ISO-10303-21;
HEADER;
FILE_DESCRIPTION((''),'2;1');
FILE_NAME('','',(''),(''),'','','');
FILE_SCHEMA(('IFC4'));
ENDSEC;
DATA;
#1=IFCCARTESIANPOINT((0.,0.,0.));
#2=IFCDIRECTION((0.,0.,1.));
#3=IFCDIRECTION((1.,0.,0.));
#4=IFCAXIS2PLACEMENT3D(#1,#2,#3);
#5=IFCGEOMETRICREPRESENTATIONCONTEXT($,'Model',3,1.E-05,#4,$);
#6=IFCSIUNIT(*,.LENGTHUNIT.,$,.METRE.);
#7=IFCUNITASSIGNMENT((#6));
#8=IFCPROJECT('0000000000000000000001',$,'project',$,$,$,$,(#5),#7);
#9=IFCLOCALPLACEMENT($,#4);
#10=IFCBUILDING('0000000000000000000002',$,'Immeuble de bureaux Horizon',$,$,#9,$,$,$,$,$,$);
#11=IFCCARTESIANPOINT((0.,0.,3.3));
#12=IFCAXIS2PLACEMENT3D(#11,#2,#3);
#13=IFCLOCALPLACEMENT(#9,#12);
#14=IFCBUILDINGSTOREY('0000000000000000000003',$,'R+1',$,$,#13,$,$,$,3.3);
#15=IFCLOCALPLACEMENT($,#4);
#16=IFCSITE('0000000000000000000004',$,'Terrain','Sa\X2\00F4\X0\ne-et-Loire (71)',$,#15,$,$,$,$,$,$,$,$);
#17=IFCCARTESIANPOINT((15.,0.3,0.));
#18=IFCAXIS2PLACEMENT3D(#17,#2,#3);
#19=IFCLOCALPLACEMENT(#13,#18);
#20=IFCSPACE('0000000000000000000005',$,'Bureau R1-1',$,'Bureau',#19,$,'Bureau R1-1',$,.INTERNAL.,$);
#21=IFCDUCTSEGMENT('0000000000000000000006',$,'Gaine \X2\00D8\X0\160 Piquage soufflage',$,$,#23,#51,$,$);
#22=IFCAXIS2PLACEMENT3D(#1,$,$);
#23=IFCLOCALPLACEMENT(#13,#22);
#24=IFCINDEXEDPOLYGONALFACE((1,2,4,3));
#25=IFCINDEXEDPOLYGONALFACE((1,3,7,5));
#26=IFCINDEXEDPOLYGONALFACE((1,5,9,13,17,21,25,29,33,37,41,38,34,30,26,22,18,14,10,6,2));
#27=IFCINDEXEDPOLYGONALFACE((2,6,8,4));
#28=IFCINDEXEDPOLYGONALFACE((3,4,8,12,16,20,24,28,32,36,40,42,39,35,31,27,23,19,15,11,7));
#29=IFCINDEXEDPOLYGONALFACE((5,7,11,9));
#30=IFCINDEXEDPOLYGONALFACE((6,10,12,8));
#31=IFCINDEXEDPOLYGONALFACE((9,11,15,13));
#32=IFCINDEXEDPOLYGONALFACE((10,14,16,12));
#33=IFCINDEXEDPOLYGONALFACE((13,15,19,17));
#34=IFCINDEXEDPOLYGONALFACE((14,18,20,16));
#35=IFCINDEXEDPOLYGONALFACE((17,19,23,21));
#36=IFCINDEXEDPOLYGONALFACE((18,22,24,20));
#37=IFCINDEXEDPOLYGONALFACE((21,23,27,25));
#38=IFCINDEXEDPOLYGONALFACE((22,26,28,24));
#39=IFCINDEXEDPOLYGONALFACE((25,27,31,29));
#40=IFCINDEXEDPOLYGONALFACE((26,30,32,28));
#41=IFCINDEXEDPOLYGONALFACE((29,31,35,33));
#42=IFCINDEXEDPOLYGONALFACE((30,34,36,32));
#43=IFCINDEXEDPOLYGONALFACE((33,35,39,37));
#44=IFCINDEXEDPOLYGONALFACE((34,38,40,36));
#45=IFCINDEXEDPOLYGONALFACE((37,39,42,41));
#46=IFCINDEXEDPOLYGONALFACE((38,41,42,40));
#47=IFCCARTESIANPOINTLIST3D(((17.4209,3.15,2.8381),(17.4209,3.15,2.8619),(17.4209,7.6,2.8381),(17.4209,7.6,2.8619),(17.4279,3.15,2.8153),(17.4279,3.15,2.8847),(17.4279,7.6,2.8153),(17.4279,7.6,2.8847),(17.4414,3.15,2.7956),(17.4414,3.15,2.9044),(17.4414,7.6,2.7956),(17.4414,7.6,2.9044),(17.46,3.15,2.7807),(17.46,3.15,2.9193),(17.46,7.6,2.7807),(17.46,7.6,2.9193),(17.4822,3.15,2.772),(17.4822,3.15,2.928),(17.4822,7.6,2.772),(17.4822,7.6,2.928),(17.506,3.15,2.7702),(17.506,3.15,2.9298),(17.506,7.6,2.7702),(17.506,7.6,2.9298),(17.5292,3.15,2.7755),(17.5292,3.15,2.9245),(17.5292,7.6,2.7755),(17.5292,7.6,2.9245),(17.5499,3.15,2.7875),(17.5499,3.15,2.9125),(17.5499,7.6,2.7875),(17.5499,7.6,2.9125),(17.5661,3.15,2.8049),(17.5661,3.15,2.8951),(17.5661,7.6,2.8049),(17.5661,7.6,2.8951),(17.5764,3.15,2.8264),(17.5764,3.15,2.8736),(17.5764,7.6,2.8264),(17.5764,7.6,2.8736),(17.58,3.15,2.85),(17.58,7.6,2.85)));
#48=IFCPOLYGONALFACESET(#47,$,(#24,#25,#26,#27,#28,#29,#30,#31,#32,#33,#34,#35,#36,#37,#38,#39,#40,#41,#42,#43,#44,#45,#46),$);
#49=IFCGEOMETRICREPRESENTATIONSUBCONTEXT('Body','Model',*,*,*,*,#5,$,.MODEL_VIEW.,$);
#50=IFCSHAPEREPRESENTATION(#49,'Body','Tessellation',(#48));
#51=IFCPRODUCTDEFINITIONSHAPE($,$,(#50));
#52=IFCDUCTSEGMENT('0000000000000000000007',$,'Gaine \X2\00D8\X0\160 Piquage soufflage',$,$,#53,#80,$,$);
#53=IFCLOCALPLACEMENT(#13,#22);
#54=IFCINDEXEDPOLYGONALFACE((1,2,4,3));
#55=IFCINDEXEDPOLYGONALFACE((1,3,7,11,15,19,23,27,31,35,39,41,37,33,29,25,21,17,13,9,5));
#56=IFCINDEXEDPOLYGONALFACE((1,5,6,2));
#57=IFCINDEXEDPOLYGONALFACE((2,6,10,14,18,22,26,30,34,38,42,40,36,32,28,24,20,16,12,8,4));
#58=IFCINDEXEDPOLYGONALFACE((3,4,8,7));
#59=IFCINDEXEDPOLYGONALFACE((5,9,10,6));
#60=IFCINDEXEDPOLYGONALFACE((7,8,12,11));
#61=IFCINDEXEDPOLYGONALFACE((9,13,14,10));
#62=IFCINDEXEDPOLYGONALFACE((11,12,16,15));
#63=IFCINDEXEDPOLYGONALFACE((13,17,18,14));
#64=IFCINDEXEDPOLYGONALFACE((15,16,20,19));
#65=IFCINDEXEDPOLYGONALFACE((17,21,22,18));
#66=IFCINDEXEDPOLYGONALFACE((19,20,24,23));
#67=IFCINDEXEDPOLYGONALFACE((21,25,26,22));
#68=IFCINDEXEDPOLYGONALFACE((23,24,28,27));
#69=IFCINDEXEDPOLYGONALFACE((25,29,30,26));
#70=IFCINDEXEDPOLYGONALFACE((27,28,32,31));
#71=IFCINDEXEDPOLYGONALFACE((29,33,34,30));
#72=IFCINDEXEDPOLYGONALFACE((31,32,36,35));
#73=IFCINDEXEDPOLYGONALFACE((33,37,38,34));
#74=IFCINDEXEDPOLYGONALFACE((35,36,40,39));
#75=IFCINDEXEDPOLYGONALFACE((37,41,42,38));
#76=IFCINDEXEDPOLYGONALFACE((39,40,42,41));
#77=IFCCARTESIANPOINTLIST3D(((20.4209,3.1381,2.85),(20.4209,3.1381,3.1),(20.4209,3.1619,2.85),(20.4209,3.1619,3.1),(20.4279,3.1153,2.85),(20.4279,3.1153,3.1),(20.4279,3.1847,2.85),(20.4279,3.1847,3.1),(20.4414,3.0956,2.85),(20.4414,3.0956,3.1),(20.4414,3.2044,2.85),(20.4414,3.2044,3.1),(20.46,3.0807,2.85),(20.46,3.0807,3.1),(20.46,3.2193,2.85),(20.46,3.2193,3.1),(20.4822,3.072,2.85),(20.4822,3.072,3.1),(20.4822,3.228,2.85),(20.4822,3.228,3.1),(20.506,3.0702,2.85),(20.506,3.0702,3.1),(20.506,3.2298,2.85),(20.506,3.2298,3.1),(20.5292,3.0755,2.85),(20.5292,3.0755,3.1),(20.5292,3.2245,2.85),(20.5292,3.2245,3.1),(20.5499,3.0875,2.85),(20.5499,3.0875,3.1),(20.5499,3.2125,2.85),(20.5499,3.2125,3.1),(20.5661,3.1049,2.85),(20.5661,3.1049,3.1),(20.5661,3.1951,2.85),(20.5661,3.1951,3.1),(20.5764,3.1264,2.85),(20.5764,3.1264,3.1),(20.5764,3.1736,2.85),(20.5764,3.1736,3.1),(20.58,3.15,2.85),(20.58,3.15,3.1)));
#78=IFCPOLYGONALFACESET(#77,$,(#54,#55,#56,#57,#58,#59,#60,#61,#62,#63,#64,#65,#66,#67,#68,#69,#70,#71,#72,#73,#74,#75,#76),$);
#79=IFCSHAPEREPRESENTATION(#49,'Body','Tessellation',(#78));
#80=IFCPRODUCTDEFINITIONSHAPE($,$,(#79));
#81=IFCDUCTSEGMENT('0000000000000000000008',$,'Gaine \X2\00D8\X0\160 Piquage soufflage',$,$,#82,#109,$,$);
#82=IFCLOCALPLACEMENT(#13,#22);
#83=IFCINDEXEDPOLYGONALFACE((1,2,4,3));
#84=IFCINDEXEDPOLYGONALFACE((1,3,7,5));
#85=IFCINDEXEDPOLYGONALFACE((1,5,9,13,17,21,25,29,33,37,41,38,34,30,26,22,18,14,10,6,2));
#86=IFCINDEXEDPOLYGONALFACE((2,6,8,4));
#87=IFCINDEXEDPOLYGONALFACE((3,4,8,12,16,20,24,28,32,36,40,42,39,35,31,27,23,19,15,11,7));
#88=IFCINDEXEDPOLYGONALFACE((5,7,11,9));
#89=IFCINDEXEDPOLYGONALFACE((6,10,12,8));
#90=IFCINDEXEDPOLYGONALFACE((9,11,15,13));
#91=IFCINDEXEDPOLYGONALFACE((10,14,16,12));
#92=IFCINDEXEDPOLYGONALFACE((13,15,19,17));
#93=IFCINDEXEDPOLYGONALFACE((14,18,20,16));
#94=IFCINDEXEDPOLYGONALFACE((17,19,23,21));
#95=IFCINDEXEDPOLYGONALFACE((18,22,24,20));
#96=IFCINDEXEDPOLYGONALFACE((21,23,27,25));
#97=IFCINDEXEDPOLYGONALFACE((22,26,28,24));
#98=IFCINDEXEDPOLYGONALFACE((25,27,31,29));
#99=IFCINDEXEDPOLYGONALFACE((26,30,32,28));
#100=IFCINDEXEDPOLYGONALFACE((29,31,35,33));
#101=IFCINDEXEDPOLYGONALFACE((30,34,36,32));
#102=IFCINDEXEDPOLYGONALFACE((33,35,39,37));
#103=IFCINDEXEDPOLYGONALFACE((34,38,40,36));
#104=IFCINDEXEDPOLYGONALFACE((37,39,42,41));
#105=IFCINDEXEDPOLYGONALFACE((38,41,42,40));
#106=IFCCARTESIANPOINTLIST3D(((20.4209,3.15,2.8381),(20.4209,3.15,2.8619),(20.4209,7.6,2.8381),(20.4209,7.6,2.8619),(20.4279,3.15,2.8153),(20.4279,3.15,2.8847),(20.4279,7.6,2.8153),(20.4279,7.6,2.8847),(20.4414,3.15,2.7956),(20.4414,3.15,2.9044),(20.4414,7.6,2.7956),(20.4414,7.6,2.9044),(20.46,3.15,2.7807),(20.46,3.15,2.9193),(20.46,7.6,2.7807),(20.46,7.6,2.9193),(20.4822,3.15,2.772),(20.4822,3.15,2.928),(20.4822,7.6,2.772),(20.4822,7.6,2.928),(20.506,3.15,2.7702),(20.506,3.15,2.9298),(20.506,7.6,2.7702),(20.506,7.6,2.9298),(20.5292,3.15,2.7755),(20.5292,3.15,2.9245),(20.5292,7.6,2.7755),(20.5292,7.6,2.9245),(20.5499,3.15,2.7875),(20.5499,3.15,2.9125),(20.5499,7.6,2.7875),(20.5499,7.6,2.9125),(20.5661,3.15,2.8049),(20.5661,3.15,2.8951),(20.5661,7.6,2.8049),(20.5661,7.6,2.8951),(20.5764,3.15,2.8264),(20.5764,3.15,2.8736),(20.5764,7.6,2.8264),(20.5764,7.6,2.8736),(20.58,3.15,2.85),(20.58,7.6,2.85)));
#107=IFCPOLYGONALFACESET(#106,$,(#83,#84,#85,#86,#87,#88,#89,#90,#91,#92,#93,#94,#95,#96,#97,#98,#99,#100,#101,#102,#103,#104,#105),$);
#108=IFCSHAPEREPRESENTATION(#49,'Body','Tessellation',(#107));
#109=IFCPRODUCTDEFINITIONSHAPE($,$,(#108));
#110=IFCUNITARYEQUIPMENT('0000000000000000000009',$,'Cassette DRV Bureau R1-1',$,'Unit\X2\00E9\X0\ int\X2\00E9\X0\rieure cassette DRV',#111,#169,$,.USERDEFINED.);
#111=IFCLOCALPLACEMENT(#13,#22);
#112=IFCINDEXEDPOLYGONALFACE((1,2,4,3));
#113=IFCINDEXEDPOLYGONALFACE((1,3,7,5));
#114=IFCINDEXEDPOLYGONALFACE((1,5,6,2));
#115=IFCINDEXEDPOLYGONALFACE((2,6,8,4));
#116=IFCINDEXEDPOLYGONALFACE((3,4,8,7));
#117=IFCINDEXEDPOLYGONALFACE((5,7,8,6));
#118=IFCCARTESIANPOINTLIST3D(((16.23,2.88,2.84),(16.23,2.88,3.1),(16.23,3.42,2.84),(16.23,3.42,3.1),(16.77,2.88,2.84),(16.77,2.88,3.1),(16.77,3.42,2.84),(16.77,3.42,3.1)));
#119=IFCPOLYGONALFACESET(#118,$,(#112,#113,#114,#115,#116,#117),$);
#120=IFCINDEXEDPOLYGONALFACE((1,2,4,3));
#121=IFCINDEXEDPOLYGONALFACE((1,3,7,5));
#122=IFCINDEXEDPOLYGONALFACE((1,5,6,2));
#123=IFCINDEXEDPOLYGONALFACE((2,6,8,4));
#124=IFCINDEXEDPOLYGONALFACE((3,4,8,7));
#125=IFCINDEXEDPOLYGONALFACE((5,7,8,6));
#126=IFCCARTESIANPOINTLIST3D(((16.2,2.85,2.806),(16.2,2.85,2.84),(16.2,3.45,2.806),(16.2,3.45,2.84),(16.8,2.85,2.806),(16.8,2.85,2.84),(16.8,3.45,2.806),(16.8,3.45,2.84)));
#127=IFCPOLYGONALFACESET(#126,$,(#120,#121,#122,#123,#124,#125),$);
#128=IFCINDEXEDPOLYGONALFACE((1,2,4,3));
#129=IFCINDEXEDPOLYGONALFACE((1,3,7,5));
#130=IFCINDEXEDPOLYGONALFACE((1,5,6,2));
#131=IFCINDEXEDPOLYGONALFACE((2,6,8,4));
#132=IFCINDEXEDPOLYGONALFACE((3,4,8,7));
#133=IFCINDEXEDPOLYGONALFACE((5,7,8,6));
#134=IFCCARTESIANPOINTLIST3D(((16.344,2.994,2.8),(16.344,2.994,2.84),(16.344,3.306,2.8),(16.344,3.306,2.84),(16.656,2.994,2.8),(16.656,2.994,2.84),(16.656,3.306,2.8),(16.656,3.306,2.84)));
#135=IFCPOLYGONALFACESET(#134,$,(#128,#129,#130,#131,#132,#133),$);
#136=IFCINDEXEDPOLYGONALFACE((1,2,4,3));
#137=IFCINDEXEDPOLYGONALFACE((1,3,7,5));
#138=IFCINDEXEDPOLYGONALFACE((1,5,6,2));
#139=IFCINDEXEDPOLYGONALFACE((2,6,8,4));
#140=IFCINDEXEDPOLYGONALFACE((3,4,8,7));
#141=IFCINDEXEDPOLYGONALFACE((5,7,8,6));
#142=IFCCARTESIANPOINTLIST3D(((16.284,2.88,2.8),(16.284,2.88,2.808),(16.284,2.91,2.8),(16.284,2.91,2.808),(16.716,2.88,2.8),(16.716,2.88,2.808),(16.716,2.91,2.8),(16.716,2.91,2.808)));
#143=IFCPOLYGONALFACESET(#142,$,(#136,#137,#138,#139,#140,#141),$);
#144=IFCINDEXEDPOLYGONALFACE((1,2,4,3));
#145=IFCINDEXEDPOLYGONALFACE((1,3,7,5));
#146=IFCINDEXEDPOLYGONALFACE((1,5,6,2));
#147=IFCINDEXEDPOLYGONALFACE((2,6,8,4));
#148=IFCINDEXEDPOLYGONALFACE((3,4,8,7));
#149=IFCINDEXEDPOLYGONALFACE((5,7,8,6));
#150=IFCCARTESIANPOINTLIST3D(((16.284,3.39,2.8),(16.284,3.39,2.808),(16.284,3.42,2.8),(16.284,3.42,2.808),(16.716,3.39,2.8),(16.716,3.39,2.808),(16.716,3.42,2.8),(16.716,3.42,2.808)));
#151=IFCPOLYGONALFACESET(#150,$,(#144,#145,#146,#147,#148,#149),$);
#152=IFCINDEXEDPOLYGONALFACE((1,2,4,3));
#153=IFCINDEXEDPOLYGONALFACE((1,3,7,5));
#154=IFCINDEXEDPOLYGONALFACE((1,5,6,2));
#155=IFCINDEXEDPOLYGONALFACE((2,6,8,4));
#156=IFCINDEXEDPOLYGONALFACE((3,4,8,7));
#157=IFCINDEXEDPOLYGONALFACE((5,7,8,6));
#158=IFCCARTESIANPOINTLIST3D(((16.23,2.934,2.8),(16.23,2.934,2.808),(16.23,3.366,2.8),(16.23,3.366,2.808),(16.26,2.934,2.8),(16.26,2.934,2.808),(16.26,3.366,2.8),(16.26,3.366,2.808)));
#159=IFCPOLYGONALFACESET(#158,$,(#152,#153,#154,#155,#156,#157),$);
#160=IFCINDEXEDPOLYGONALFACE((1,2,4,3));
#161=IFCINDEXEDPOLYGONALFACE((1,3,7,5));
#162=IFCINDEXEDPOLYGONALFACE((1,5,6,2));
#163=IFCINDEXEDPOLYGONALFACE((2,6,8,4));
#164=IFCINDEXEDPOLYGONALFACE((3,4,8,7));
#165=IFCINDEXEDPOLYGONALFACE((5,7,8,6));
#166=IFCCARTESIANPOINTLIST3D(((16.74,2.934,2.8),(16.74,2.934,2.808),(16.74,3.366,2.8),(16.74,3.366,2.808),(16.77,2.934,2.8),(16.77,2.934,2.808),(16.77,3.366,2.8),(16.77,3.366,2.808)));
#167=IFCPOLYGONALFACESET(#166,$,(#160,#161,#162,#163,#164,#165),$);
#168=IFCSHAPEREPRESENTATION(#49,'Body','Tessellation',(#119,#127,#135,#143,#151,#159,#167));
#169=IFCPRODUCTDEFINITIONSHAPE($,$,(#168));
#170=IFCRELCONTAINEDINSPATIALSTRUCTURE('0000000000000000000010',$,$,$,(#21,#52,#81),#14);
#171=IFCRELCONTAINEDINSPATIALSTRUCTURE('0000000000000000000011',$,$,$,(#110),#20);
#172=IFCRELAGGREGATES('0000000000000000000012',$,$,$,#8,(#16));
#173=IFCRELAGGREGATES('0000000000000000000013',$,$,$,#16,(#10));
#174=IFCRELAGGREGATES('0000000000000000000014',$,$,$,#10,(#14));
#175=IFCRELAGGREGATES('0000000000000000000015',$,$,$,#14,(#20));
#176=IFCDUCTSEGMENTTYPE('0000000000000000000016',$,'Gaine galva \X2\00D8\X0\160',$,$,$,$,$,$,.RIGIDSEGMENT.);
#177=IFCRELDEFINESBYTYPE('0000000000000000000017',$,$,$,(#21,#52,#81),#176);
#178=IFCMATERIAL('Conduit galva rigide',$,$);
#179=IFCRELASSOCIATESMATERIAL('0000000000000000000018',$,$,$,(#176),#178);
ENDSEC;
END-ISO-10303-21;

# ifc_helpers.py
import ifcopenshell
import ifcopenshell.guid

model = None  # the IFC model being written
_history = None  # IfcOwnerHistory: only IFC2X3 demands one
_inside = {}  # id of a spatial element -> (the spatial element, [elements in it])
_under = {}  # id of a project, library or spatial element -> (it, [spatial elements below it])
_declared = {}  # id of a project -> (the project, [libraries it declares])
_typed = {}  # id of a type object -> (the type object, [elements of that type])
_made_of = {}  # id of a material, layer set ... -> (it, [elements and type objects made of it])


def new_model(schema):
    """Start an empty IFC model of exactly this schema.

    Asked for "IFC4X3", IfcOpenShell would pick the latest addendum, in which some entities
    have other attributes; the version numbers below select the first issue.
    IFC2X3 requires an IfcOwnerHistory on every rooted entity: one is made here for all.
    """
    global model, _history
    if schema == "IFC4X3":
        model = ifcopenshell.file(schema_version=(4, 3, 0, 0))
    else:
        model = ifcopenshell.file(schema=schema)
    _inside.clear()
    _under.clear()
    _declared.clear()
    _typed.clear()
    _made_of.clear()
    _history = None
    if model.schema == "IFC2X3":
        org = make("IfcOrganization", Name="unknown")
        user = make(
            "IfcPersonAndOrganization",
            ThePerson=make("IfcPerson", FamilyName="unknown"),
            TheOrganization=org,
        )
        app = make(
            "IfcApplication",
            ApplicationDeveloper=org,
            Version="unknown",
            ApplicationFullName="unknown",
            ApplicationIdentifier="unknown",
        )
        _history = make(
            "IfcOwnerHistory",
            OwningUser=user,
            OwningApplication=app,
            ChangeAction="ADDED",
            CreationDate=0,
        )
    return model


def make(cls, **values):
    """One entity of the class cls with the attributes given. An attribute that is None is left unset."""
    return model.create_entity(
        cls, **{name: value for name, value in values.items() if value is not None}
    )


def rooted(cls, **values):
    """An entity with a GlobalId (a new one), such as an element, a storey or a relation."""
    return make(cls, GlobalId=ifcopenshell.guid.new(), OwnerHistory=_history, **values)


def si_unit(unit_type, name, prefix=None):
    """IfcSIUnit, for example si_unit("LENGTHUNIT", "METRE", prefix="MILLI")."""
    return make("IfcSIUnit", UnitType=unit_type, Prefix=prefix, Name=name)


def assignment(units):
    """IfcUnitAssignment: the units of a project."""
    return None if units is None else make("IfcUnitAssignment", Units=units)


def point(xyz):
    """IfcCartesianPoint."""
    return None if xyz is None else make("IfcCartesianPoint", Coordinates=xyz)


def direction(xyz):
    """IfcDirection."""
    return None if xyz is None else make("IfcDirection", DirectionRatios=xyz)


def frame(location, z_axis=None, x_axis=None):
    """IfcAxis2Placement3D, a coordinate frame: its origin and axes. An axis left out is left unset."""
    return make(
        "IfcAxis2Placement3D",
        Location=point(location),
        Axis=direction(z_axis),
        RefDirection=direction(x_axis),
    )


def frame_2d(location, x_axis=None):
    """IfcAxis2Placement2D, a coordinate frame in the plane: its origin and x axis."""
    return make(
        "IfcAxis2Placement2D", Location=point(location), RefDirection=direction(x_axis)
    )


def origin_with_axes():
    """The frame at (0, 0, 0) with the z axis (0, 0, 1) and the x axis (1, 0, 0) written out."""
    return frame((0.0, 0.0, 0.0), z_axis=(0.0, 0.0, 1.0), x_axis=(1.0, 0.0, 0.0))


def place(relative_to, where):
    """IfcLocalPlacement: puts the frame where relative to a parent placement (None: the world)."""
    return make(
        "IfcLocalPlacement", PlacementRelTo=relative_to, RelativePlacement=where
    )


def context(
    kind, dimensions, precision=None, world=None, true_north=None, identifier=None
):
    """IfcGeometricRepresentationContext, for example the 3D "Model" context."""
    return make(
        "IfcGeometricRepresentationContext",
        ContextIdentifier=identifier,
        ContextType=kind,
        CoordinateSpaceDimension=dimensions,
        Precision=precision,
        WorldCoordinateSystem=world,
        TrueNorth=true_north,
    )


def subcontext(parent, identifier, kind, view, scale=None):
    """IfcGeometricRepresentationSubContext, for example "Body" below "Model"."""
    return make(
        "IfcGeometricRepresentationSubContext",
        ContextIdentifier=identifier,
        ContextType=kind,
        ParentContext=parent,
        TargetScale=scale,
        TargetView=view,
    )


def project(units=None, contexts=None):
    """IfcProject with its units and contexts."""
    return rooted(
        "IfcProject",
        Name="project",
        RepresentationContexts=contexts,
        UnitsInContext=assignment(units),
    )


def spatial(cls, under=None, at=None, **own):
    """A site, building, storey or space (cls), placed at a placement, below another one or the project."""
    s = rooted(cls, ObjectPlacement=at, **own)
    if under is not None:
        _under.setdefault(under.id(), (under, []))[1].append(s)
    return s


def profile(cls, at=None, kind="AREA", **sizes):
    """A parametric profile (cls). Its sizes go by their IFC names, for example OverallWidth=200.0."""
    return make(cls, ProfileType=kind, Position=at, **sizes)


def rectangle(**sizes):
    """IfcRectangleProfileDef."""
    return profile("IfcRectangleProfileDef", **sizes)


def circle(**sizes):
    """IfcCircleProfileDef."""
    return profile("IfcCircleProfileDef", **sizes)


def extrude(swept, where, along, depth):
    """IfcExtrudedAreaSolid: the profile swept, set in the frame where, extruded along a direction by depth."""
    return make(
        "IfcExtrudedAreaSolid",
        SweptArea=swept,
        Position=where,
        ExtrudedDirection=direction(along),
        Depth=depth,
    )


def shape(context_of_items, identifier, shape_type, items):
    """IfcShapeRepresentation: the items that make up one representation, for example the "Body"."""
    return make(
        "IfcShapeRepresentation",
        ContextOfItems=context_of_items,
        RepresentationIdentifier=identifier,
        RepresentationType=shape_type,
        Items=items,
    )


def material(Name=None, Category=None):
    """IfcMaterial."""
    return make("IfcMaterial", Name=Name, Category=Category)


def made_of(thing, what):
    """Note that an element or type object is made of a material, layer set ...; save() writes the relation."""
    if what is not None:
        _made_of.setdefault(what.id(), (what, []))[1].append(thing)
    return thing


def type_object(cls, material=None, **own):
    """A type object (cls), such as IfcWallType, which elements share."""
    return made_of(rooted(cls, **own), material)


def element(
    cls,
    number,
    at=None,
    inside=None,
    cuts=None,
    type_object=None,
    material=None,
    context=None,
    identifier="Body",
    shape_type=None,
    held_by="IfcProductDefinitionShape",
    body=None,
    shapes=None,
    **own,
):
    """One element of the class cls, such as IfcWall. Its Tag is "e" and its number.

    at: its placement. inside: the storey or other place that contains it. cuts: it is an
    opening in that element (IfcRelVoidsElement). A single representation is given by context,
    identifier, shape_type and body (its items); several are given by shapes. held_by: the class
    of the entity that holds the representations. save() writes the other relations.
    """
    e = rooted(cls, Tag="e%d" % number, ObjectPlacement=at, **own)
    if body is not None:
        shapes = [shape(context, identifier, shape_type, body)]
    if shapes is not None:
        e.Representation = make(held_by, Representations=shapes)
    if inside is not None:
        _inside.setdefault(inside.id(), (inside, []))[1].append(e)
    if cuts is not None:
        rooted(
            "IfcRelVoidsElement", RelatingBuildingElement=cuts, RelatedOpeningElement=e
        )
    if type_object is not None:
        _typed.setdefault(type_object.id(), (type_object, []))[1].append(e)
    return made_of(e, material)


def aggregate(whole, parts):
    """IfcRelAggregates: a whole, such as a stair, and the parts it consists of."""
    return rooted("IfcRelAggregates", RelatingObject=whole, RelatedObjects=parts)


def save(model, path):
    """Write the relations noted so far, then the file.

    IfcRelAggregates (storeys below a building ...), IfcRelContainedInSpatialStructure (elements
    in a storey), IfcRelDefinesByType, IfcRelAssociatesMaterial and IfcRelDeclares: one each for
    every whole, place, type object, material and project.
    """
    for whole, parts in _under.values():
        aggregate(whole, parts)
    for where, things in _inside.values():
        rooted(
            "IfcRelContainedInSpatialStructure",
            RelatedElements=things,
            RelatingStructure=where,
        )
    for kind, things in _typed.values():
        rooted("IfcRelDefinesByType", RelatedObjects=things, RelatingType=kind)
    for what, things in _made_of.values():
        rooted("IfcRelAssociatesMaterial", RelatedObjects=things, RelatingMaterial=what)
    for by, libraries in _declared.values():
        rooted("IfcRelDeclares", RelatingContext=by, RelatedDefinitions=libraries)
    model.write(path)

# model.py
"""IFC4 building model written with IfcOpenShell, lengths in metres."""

from ifc_helpers import new_model, si_unit, frame, frame_2d, origin_with_axes, place, context, subcontext, project, spatial, rectangle, circle, extrude, material, type_object, element, save


model = new_model("IFC4")

# Units and contexts
model_context = context("Model", 3, precision=1e-05, world=origin_with_axes())
body_context = subcontext(model_context, "Body", "Model", "MODEL_VIEW")
ifc_project = project(units=[si_unit("LENGTHUNIT", "METRE")], contexts=[model_context])

# Site, building, storey
site_placement = place(None, origin_with_axes())
site = spatial("IfcSite", under=ifc_project, at=site_placement, Name="Terrain", Description="Saône-et-Loire (71)")
building_placement = place(None, origin_with_axes())
building = spatial("IfcBuilding", under=site, at=building_placement, Name="Immeuble de bureaux Horizon")
storey_placement = place(building_placement, frame((0.0, 0.0, 3.3), z_axis=(0.0, 0.0, 1.0), x_axis=(1.0, 0.0, 0.0)))
storey = spatial("IfcBuildingStorey", under=building, at=storey_placement, Name="R+1", Elevation=3.3)

# Duct segments
ifc_material_1 = material(Name="Conduit galva rigide")
duct_segment_type = type_object("IfcDuctSegmentType", Name="Gaine galva Ø160", PredefinedType="RIGIDSEGMENT", material=ifc_material_1)
duct_segment_1_placement = place(storey_placement, frame((17.5, 3.15, 2.85), z_axis=(0.0, 1.0, 0.0), x_axis=(1.0, 0.0, 0.0)))
element("IfcDuctSegment", 1, at=duct_segment_1_placement, inside=storey, type_object=duct_segment_type, Name="Gaine Ø160 Piquage soufflage", context=body_context, shape_type="SweptSolid", body=[
    extrude(circle(Radius=0.08), origin_with_axes(), (0.0, 0.0, 1.0), 4.45),
])
duct_segment_2_placement = place(storey_placement, frame((20.5, 3.15, 3.1), z_axis=(0.0, 0.0, -1.0), x_axis=(1.0, 0.0, 0.0)))
element("IfcDuctSegment", 2, at=duct_segment_2_placement, inside=storey, type_object=duct_segment_type, Name="Gaine Ø160 Piquage soufflage", context=body_context, shape_type="SweptSolid", body=[
    extrude(circle(Radius=0.08), origin_with_axes(), (0.0, 0.0, 1.0), 0.25),
])
duct_segment_3_placement = place(storey_placement, frame((20.5, 3.15, 2.85), z_axis=(0.0, 1.0, 0.0), x_axis=(1.0, 0.0, 0.0)))
element("IfcDuctSegment", 3, at=duct_segment_3_placement, inside=storey, type_object=duct_segment_type, Name="Gaine Ø160 Piquage soufflage", context=body_context, shape_type="SweptSolid", body=[
    extrude(circle(Radius=0.08), origin_with_axes(), (0.0, 0.0, 1.0), 4.45),
])

# Shared definitions
space_1_placement = place(storey_placement, frame((15.0, 0.3, 0.0), z_axis=(0.0, 0.0, 1.0), x_axis=(1.0, 0.0, 0.0)))
space_1 = spatial("IfcSpace", under=storey, at=space_1_placement, Name="Bureau R1-1", ObjectType="Bureau", LongName="Bureau R1-1", PredefinedType="INTERNAL")

# Unitary equipment
unitary_equipment_1_placement = place(space_1_placement, frame((1.2, 2.55, 2.8), z_axis=(0.0, 0.0, 1.0), x_axis=(1.0, 0.0, 0.0)))
element("IfcUnitaryEquipment", 4, at=unitary_equipment_1_placement, inside=space_1, Name="Cassette DRV Bureau R1-1", ObjectType="Unité intérieure cassette DRV", PredefinedType="USERDEFINED", context=body_context, shape_type="SweptSolid", body=[
    extrude(rectangle(XDim=0.54, YDim=0.54, at=frame_2d((0.27, 0.27))), frame((0.03, 0.03, 0.04), z_axis=(0.0, 0.0, 1.0), x_axis=(1.0, 0.0, 0.0)), (0.0, 0.0, 1.0), 0.26),
    extrude(rectangle(XDim=0.6, YDim=0.6, at=frame_2d((0.3, 0.3))), frame((0.0, 0.0, 0.006), z_axis=(0.0, 0.0, 1.0), x_axis=(1.0, 0.0, 0.0)), (0.0, 0.0, 1.0), 0.034),
    extrude(rectangle(XDim=0.312, YDim=0.312, at=frame_2d((0.156, 0.156))), frame((0.144, 0.144, 0.0), z_axis=(0.0, 0.0, 1.0), x_axis=(1.0, 0.0, 0.0)), (0.0, 0.0, 1.0), 0.04),
    extrude(rectangle(XDim=0.432, YDim=0.03, at=frame_2d((0.216, 0.015))), frame((0.084, 0.03, 0.0), z_axis=(0.0, 0.0, 1.0), x_axis=(1.0, 0.0, 0.0)), (0.0, 0.0, 1.0), 0.008),
    extrude(rectangle(XDim=0.432, YDim=0.03, at=frame_2d((0.216, 0.015))), frame((0.084, 0.54, 0.0), z_axis=(0.0, 0.0, 1.0), x_axis=(1.0, 0.0, 0.0)), (0.0, 0.0, 1.0), 0.008),
    extrude(rectangle(XDim=0.03, YDim=0.432, at=frame_2d((0.015, 0.216))), frame((0.03, 0.084, 0.0), z_axis=(0.0, 0.0, 1.0), x_axis=(1.0, 0.0, 0.0)), (0.0, 0.0, 1.0), 0.008),
    extrude(rectangle(XDim=0.03, YDim=0.432, at=frame_2d((0.015, 0.216))), frame((0.54, 0.084, 0.0), z_axis=(0.0, 0.0, 1.0), x_axis=(1.0, 0.0, 0.0)), (0.0, 0.0, 1.0), 0.008),
])

save(model, "model.ifc")
